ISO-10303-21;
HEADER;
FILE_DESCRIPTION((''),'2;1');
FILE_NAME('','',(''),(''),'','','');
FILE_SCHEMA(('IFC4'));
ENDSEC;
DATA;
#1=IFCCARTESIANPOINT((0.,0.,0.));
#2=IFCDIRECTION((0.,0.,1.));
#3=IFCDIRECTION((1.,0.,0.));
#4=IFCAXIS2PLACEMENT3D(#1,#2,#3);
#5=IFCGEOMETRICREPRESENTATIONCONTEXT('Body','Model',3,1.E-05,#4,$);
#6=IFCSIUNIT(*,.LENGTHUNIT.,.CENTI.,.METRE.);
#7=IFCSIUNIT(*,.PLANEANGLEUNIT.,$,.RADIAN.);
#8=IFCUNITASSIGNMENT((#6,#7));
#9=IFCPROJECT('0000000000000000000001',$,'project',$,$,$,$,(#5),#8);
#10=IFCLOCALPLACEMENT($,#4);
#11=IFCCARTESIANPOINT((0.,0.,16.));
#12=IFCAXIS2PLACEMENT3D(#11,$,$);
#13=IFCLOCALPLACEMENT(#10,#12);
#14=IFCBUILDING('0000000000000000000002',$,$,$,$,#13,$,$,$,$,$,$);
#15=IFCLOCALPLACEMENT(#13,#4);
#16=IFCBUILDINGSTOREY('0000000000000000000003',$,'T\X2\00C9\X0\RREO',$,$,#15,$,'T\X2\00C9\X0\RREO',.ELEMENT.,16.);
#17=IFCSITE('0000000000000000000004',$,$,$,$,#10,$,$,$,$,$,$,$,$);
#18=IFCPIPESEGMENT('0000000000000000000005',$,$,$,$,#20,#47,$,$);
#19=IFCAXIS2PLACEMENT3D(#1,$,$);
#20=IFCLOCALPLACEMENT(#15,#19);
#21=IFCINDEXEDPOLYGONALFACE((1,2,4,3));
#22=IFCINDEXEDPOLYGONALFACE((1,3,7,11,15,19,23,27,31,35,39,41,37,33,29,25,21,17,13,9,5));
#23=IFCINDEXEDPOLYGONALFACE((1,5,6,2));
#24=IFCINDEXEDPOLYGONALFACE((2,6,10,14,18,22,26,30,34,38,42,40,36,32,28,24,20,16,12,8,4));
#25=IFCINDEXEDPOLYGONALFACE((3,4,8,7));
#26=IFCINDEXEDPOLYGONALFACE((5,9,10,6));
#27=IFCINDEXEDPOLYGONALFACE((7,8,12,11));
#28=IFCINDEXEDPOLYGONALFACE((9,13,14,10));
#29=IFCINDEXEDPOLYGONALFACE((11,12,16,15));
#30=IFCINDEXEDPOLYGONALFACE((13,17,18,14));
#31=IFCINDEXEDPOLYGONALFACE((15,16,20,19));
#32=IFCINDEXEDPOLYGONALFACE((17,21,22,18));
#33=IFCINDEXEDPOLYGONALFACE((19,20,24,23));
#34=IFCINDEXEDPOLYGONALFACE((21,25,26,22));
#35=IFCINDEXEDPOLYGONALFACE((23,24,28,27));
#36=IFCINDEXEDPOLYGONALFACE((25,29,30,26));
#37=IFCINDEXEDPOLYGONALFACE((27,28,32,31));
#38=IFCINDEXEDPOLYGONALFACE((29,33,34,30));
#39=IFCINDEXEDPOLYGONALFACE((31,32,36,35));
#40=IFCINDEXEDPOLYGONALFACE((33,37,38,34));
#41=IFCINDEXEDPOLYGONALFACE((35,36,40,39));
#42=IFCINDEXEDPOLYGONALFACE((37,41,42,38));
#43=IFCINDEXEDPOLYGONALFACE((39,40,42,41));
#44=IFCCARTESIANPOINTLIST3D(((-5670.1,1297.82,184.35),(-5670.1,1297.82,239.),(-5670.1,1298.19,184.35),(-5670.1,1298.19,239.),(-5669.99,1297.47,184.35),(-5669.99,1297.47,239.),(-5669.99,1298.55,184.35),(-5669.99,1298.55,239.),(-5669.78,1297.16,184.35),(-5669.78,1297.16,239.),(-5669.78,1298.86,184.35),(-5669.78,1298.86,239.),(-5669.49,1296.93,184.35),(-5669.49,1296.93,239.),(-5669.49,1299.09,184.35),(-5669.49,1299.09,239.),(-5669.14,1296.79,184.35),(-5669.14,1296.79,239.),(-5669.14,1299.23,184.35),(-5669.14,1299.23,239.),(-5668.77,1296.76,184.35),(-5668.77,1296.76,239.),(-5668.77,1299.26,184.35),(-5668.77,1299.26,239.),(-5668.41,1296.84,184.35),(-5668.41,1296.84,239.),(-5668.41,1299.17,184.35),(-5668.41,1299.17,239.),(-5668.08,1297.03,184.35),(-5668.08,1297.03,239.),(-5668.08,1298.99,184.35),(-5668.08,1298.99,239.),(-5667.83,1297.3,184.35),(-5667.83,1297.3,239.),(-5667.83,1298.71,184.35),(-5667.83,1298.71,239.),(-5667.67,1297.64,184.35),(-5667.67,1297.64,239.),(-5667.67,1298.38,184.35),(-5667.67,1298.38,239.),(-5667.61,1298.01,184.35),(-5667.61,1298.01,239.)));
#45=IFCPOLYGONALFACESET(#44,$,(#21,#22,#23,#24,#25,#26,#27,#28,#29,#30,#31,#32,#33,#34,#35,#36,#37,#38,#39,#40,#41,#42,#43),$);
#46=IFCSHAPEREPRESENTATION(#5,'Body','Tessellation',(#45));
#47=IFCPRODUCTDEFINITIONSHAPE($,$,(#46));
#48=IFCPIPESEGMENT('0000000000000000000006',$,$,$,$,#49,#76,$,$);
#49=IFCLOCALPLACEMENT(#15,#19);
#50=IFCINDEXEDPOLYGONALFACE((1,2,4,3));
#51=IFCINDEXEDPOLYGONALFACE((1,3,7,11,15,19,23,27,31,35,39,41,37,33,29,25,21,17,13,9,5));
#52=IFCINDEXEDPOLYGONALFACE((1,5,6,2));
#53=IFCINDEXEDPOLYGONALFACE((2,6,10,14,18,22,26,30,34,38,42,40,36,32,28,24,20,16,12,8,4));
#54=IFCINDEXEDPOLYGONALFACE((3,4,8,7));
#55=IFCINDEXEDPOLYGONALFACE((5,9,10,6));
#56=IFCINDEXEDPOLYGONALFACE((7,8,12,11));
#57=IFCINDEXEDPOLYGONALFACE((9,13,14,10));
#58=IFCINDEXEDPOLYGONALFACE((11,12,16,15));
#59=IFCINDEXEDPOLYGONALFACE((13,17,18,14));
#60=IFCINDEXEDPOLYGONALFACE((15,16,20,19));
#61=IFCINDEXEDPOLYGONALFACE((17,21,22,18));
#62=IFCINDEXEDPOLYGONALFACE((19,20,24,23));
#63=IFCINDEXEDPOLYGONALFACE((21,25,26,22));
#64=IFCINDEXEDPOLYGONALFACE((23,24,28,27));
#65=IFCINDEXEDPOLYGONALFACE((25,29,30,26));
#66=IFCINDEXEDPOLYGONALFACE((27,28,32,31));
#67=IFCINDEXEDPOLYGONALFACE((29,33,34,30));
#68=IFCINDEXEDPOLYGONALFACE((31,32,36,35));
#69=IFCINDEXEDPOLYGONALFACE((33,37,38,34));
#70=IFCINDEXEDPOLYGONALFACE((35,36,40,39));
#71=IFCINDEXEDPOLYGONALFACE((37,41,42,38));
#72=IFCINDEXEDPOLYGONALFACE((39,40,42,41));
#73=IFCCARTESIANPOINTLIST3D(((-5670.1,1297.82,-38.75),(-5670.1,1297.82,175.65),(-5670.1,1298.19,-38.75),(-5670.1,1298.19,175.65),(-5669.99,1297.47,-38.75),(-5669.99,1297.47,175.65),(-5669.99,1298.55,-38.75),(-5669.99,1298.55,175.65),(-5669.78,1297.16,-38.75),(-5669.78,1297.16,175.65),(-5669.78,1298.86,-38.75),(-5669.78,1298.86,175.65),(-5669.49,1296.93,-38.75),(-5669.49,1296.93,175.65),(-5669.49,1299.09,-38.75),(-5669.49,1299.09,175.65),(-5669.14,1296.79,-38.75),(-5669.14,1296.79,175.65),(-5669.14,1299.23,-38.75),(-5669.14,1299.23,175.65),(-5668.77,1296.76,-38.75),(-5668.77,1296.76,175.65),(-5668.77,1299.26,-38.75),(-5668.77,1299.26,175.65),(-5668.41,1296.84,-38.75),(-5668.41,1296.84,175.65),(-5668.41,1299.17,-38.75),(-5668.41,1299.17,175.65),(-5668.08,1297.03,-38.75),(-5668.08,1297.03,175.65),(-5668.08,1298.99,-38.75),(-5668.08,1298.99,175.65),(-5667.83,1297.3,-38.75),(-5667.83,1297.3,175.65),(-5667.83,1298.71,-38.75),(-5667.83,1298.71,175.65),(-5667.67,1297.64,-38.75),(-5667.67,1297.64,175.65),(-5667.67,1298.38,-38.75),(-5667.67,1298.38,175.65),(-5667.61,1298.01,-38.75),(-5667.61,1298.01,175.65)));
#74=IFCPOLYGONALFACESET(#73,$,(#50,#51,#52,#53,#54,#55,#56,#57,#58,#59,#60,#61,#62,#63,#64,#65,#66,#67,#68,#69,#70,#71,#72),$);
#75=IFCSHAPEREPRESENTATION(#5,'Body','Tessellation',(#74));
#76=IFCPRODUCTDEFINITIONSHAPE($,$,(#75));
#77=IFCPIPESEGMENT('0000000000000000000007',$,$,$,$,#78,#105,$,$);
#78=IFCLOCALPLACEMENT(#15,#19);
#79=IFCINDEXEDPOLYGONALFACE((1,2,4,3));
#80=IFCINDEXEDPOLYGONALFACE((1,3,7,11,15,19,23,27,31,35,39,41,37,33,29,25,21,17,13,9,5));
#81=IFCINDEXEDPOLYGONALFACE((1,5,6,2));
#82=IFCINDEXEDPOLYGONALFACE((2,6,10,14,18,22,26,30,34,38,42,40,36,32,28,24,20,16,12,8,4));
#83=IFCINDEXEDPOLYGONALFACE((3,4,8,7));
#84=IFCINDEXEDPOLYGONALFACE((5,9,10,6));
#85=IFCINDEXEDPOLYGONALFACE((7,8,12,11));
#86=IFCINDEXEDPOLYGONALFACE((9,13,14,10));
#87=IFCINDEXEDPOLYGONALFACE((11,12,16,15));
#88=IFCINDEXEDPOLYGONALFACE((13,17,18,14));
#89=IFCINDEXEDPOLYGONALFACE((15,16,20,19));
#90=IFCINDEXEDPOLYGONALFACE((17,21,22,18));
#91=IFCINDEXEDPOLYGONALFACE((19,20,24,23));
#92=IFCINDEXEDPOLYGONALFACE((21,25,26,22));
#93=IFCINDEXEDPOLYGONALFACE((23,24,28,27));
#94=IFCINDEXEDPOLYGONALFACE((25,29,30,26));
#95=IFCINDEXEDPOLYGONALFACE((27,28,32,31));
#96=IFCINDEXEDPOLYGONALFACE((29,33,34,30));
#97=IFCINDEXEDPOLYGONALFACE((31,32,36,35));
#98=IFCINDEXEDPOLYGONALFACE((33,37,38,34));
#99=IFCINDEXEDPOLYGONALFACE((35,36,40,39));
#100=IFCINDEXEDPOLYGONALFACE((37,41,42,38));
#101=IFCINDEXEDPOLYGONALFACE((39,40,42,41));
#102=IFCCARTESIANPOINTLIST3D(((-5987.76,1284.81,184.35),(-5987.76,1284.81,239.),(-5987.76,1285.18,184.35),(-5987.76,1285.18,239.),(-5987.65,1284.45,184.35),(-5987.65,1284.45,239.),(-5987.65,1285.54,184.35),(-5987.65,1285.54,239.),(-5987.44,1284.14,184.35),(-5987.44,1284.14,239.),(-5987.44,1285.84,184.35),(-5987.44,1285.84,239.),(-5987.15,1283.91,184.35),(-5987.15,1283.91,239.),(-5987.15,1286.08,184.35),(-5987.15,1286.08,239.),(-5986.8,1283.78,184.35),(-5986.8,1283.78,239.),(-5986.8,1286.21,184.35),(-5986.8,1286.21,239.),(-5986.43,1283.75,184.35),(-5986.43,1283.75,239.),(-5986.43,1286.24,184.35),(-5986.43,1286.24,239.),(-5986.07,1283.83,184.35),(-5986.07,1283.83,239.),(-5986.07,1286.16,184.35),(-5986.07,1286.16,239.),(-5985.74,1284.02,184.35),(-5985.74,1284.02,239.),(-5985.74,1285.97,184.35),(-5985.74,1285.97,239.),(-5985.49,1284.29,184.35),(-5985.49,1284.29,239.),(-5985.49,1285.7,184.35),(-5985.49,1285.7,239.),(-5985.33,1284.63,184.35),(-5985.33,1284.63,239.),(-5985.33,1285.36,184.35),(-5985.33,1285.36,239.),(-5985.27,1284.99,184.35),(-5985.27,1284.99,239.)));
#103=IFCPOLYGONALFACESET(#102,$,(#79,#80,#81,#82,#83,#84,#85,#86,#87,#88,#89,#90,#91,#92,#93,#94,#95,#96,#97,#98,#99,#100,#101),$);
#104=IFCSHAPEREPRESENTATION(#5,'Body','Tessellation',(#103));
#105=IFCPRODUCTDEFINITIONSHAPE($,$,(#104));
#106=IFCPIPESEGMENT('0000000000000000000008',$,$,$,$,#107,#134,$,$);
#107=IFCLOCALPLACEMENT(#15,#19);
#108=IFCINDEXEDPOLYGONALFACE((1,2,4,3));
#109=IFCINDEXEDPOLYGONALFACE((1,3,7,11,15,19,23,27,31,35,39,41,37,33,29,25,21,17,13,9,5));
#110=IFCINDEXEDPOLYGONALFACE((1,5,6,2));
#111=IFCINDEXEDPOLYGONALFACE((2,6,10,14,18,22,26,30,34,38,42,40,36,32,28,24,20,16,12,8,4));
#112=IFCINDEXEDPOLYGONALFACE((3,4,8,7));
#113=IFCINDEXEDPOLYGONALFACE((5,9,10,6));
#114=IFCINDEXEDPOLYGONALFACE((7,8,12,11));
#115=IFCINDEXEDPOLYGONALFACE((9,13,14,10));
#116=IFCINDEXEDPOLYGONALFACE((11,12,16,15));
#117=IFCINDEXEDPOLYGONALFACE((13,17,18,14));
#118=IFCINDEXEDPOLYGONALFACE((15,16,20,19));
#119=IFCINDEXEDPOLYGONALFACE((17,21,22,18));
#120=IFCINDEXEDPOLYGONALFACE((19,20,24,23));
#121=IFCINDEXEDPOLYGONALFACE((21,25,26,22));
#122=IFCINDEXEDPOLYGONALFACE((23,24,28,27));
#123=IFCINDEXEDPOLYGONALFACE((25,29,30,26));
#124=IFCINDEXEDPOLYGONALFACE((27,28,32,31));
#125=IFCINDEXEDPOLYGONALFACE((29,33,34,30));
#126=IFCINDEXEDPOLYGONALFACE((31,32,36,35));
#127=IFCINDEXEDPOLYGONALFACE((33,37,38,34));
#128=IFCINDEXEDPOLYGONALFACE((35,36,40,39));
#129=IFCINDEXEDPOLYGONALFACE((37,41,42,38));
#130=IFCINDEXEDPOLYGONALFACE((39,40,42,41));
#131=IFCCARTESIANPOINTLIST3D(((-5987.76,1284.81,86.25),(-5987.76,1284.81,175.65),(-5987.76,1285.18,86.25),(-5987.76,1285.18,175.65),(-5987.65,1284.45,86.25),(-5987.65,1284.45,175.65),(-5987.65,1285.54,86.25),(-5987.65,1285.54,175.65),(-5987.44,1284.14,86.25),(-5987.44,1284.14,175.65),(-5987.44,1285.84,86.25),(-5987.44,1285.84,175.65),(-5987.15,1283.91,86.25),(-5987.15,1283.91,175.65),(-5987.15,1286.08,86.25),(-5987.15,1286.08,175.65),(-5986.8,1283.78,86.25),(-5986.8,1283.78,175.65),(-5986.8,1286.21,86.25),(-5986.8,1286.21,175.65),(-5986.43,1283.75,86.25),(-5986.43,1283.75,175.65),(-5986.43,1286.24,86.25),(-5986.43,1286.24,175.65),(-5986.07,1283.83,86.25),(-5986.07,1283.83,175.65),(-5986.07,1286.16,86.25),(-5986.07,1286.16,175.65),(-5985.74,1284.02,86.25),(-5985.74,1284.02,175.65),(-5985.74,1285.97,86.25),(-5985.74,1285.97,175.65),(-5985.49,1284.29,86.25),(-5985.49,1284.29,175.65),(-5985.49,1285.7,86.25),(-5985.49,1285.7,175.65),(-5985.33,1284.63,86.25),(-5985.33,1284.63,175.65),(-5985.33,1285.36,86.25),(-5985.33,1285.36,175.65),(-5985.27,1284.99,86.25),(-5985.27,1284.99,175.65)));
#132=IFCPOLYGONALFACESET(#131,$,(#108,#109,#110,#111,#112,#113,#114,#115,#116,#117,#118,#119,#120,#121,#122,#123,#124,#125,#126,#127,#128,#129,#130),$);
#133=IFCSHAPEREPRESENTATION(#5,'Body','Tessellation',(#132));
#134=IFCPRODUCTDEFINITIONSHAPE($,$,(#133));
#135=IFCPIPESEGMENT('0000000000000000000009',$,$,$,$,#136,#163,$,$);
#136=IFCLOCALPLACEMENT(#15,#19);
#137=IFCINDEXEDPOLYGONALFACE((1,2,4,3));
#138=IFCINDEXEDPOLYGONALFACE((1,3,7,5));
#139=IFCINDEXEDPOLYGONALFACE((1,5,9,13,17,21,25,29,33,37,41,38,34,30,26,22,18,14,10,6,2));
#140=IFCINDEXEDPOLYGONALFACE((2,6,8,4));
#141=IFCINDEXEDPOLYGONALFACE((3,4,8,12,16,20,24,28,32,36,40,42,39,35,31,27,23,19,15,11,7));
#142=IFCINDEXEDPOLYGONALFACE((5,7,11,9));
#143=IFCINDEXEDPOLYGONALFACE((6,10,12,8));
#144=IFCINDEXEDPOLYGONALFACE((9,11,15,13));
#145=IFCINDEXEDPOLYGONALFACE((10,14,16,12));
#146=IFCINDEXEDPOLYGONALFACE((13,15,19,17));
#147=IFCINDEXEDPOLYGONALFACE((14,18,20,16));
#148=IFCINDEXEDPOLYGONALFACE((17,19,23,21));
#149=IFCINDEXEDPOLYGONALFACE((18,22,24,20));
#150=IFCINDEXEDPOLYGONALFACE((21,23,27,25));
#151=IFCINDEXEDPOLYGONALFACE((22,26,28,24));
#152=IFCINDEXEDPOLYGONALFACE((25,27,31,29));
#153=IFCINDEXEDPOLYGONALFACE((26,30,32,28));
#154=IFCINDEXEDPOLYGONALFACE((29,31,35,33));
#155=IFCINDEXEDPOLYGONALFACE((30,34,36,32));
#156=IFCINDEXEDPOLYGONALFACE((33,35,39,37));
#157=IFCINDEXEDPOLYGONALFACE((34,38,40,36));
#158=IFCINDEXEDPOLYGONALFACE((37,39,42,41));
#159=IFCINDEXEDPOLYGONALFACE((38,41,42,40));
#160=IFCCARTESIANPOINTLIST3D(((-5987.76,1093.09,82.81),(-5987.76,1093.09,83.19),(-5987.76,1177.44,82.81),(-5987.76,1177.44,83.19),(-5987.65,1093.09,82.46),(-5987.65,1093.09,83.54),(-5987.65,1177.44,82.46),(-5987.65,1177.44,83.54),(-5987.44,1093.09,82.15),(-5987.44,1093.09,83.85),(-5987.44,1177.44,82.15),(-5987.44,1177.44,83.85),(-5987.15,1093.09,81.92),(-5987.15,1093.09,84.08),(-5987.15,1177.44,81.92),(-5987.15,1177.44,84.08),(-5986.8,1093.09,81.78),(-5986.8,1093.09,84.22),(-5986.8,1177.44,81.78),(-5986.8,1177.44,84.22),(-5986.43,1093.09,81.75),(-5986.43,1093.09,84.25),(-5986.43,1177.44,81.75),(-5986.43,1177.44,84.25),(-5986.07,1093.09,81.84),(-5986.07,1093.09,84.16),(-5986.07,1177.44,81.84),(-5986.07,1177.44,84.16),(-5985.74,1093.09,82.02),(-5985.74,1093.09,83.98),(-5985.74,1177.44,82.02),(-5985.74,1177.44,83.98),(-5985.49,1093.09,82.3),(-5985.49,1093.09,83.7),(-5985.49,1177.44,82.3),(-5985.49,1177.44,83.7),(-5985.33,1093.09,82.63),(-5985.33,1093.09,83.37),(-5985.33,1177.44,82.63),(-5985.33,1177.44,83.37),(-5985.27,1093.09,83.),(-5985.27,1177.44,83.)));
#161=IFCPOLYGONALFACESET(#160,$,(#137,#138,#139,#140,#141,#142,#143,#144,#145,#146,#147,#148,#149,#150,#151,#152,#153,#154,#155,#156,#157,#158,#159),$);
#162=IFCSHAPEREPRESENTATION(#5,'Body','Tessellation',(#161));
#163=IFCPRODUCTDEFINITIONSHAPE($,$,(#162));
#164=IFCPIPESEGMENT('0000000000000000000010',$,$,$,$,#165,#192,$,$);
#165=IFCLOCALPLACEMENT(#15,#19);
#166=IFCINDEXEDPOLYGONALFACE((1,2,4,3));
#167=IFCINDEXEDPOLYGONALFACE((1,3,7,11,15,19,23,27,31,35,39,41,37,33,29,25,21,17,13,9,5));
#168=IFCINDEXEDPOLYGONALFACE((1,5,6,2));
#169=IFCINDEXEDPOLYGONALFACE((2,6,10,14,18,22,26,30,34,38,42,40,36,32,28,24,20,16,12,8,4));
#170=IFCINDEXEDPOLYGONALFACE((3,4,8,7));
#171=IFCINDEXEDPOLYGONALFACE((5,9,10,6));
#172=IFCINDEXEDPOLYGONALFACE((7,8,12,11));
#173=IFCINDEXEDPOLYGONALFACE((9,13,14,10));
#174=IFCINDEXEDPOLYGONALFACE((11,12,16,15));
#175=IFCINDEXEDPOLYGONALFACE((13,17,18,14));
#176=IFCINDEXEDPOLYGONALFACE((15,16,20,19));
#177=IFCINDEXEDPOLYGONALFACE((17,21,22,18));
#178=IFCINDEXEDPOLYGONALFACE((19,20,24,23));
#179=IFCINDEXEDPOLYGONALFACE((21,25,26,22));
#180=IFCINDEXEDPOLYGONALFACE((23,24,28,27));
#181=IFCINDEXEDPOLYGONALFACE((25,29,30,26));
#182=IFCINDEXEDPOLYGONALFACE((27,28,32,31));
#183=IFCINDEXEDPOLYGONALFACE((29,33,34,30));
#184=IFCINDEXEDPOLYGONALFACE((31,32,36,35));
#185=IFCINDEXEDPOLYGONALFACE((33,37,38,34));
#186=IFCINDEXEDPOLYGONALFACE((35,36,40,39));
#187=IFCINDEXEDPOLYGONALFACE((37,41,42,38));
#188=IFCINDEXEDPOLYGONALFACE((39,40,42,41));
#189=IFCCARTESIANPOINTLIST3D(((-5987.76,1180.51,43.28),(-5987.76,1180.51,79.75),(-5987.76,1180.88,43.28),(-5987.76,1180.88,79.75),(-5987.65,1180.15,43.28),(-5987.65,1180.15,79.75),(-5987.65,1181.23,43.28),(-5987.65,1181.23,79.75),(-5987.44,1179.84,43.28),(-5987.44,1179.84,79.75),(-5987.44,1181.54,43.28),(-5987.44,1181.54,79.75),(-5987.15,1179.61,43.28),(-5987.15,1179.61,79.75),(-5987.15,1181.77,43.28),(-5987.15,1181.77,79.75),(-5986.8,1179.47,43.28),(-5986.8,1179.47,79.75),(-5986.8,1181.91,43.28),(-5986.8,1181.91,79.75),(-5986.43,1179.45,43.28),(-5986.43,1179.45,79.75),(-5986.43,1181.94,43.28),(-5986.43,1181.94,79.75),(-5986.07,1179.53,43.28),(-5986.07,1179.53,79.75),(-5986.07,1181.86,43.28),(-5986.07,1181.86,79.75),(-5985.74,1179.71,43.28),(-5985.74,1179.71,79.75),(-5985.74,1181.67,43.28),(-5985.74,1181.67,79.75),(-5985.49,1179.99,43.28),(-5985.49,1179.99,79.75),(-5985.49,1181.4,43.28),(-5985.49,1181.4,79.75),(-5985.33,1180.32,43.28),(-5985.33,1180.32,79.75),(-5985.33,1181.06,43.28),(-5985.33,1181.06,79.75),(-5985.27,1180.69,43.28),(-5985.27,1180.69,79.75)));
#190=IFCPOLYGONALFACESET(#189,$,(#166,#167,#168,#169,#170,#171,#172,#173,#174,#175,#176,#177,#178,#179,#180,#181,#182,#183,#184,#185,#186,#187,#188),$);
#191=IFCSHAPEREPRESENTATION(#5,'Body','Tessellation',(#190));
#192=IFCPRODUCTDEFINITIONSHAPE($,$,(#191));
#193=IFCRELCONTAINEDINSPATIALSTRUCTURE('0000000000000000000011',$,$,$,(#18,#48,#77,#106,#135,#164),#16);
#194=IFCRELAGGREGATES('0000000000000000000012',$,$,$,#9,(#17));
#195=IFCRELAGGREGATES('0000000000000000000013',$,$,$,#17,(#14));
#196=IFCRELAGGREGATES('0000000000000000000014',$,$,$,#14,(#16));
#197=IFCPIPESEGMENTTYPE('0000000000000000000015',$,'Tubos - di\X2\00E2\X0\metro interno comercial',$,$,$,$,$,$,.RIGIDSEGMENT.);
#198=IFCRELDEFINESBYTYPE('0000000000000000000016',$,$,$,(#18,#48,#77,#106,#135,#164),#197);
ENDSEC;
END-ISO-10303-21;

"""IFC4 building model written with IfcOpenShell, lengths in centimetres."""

from ifc_helpers import new_model, si_unit, frame, origin_with_axes, origin_2d_with_axis, place, context, project, spatial, circle, extrude, type_object, element, save


model = new_model("IFC4")

# Units and contexts
model_context = context("Model", 3, precision=1e-05, world=origin_with_axes(), identifier="Body")
ifc_project = project(units=[si_unit("LENGTHUNIT", "METRE", prefix="CENTI"), si_unit("PLANEANGLEUNIT", "RADIAN")], contexts=[model_context])

# Site, building, storey
site_placement = place(None, origin_with_axes())
site = spatial("IfcSite", under=ifc_project, at=site_placement)
building_placement = place(site_placement, frame((0.0, 0.0, 16.0)))
building = spatial("IfcBuilding", under=site, at=building_placement)
storey_placement = place(building_placement, origin_with_axes())
storey = spatial("IfcBuildingStorey", under=building, at=storey_placement, Name="TÉRREO", LongName="TÉRREO", CompositionType="ELEMENT", Elevation=16.0)

# Pipe segments
pipe_segment_type = type_object("IfcPipeSegmentType", Name="Tubos - diâmetro interno comercial", PredefinedType="RIGIDSEGMENT")
pipe_segment_1_placement = place(storey_placement, frame((-5668.86, 1298.01, 239.0), z_axis=(0.0, 0.0, 1.0), x_axis=(1.0, 0.0, 0.0)))
element("IfcPipeSegment", 1, at=pipe_segment_1_placement, inside=storey, type_object=pipe_segment_type, context=model_context, shape_type="SolidModel", body=[
    extrude(circle(Radius=1.25, at=origin_2d_with_axis()), frame((0.0, 0.0, 0.0), z_axis=(0.0, 0.0, -1.0), x_axis=(1.0, 0.0, 0.0)), (0.0, 0.0, 1.0), 54.65),
])
pipe_segment_2_placement = place(storey_placement, frame((-5668.86, 1298.01, 175.65), z_axis=(0.0, 0.0, 1.0), x_axis=(1.0, 0.0, 0.0)))
element("IfcPipeSegment", 2, at=pipe_segment_2_placement, inside=storey, type_object=pipe_segment_type, context=model_context, shape_type="SolidModel", body=[
    extrude(circle(Radius=1.25, at=origin_2d_with_axis()), frame((0.0, 0.0, 0.0), z_axis=(0.0, 0.0, -1.0), x_axis=(1.0, 0.0, 0.0)), (0.0, 0.0, 1.0), 214.4),
])
pipe_segment_3_placement = place(storey_placement, frame((-5986.52, 1284.99, 239.0), z_axis=(0.0, 0.0, 1.0), x_axis=(1.0, 0.0, 0.0)))
element("IfcPipeSegment", 3, at=pipe_segment_3_placement, inside=storey, type_object=pipe_segment_type, context=model_context, shape_type="SolidModel", body=[
    extrude(circle(Radius=1.25, at=origin_2d_with_axis()), frame((0.0, 0.0, 0.0), z_axis=(0.0, 0.0, -1.0), x_axis=(1.0, 0.0, 0.0)), (0.0, 0.0, 1.0), 54.65),
])
pipe_segment_4_placement = place(storey_placement, frame((-5986.52, 1284.99, 175.65), z_axis=(0.0, 0.0, 1.0), x_axis=(1.0, 0.0, 0.0)))
element("IfcPipeSegment", 4, at=pipe_segment_4_placement, inside=storey, type_object=pipe_segment_type, context=model_context, shape_type="SolidModel", body=[
    extrude(circle(Radius=1.25, at=origin_2d_with_axis()), frame((0.0, 0.0, 0.0), z_axis=(0.0, 0.0, -1.0), x_axis=(1.0, 0.0, 0.0)), (0.0, 0.0, 1.0), 89.4),
])
pipe_segment_5_placement = place(storey_placement, frame((-5986.52, 1135.27, 84.25), z_axis=(0.0, 0.0, 1.0), x_axis=(1.0, 0.0, 0.0)))
element("IfcPipeSegment", 5, at=pipe_segment_5_placement, inside=storey, type_object=pipe_segment_type, context=model_context, shape_type="SolidModel", body=[
    extrude(circle(Radius=1.25, at=origin_2d_with_axis()), frame((0.0, 42.18, -1.25), z_axis=(0.0, -1.0, 0.0), x_axis=(1.0, 0.0, 0.0)), (0.0, 0.0, 1.0), 84.35),
])
pipe_segment_6_placement = place(storey_placement, frame((-5986.52, 1180.69, 79.75), z_axis=(0.0, 0.0, 1.0), x_axis=(1.0, 0.0, 0.0)))
element("IfcPipeSegment", 6, at=pipe_segment_6_placement, inside=storey, type_object=pipe_segment_type, context=model_context, shape_type="SolidModel", body=[
    extrude(circle(Radius=1.25, at=origin_2d_with_axis()), frame((0.0, 0.0, 0.0), z_axis=(0.0, 0.0, -1.0), x_axis=(1.0, 0.0, 0.0)), (0.0, 0.0, 1.0), 36.47),
])

save(model, "model.ifc")
